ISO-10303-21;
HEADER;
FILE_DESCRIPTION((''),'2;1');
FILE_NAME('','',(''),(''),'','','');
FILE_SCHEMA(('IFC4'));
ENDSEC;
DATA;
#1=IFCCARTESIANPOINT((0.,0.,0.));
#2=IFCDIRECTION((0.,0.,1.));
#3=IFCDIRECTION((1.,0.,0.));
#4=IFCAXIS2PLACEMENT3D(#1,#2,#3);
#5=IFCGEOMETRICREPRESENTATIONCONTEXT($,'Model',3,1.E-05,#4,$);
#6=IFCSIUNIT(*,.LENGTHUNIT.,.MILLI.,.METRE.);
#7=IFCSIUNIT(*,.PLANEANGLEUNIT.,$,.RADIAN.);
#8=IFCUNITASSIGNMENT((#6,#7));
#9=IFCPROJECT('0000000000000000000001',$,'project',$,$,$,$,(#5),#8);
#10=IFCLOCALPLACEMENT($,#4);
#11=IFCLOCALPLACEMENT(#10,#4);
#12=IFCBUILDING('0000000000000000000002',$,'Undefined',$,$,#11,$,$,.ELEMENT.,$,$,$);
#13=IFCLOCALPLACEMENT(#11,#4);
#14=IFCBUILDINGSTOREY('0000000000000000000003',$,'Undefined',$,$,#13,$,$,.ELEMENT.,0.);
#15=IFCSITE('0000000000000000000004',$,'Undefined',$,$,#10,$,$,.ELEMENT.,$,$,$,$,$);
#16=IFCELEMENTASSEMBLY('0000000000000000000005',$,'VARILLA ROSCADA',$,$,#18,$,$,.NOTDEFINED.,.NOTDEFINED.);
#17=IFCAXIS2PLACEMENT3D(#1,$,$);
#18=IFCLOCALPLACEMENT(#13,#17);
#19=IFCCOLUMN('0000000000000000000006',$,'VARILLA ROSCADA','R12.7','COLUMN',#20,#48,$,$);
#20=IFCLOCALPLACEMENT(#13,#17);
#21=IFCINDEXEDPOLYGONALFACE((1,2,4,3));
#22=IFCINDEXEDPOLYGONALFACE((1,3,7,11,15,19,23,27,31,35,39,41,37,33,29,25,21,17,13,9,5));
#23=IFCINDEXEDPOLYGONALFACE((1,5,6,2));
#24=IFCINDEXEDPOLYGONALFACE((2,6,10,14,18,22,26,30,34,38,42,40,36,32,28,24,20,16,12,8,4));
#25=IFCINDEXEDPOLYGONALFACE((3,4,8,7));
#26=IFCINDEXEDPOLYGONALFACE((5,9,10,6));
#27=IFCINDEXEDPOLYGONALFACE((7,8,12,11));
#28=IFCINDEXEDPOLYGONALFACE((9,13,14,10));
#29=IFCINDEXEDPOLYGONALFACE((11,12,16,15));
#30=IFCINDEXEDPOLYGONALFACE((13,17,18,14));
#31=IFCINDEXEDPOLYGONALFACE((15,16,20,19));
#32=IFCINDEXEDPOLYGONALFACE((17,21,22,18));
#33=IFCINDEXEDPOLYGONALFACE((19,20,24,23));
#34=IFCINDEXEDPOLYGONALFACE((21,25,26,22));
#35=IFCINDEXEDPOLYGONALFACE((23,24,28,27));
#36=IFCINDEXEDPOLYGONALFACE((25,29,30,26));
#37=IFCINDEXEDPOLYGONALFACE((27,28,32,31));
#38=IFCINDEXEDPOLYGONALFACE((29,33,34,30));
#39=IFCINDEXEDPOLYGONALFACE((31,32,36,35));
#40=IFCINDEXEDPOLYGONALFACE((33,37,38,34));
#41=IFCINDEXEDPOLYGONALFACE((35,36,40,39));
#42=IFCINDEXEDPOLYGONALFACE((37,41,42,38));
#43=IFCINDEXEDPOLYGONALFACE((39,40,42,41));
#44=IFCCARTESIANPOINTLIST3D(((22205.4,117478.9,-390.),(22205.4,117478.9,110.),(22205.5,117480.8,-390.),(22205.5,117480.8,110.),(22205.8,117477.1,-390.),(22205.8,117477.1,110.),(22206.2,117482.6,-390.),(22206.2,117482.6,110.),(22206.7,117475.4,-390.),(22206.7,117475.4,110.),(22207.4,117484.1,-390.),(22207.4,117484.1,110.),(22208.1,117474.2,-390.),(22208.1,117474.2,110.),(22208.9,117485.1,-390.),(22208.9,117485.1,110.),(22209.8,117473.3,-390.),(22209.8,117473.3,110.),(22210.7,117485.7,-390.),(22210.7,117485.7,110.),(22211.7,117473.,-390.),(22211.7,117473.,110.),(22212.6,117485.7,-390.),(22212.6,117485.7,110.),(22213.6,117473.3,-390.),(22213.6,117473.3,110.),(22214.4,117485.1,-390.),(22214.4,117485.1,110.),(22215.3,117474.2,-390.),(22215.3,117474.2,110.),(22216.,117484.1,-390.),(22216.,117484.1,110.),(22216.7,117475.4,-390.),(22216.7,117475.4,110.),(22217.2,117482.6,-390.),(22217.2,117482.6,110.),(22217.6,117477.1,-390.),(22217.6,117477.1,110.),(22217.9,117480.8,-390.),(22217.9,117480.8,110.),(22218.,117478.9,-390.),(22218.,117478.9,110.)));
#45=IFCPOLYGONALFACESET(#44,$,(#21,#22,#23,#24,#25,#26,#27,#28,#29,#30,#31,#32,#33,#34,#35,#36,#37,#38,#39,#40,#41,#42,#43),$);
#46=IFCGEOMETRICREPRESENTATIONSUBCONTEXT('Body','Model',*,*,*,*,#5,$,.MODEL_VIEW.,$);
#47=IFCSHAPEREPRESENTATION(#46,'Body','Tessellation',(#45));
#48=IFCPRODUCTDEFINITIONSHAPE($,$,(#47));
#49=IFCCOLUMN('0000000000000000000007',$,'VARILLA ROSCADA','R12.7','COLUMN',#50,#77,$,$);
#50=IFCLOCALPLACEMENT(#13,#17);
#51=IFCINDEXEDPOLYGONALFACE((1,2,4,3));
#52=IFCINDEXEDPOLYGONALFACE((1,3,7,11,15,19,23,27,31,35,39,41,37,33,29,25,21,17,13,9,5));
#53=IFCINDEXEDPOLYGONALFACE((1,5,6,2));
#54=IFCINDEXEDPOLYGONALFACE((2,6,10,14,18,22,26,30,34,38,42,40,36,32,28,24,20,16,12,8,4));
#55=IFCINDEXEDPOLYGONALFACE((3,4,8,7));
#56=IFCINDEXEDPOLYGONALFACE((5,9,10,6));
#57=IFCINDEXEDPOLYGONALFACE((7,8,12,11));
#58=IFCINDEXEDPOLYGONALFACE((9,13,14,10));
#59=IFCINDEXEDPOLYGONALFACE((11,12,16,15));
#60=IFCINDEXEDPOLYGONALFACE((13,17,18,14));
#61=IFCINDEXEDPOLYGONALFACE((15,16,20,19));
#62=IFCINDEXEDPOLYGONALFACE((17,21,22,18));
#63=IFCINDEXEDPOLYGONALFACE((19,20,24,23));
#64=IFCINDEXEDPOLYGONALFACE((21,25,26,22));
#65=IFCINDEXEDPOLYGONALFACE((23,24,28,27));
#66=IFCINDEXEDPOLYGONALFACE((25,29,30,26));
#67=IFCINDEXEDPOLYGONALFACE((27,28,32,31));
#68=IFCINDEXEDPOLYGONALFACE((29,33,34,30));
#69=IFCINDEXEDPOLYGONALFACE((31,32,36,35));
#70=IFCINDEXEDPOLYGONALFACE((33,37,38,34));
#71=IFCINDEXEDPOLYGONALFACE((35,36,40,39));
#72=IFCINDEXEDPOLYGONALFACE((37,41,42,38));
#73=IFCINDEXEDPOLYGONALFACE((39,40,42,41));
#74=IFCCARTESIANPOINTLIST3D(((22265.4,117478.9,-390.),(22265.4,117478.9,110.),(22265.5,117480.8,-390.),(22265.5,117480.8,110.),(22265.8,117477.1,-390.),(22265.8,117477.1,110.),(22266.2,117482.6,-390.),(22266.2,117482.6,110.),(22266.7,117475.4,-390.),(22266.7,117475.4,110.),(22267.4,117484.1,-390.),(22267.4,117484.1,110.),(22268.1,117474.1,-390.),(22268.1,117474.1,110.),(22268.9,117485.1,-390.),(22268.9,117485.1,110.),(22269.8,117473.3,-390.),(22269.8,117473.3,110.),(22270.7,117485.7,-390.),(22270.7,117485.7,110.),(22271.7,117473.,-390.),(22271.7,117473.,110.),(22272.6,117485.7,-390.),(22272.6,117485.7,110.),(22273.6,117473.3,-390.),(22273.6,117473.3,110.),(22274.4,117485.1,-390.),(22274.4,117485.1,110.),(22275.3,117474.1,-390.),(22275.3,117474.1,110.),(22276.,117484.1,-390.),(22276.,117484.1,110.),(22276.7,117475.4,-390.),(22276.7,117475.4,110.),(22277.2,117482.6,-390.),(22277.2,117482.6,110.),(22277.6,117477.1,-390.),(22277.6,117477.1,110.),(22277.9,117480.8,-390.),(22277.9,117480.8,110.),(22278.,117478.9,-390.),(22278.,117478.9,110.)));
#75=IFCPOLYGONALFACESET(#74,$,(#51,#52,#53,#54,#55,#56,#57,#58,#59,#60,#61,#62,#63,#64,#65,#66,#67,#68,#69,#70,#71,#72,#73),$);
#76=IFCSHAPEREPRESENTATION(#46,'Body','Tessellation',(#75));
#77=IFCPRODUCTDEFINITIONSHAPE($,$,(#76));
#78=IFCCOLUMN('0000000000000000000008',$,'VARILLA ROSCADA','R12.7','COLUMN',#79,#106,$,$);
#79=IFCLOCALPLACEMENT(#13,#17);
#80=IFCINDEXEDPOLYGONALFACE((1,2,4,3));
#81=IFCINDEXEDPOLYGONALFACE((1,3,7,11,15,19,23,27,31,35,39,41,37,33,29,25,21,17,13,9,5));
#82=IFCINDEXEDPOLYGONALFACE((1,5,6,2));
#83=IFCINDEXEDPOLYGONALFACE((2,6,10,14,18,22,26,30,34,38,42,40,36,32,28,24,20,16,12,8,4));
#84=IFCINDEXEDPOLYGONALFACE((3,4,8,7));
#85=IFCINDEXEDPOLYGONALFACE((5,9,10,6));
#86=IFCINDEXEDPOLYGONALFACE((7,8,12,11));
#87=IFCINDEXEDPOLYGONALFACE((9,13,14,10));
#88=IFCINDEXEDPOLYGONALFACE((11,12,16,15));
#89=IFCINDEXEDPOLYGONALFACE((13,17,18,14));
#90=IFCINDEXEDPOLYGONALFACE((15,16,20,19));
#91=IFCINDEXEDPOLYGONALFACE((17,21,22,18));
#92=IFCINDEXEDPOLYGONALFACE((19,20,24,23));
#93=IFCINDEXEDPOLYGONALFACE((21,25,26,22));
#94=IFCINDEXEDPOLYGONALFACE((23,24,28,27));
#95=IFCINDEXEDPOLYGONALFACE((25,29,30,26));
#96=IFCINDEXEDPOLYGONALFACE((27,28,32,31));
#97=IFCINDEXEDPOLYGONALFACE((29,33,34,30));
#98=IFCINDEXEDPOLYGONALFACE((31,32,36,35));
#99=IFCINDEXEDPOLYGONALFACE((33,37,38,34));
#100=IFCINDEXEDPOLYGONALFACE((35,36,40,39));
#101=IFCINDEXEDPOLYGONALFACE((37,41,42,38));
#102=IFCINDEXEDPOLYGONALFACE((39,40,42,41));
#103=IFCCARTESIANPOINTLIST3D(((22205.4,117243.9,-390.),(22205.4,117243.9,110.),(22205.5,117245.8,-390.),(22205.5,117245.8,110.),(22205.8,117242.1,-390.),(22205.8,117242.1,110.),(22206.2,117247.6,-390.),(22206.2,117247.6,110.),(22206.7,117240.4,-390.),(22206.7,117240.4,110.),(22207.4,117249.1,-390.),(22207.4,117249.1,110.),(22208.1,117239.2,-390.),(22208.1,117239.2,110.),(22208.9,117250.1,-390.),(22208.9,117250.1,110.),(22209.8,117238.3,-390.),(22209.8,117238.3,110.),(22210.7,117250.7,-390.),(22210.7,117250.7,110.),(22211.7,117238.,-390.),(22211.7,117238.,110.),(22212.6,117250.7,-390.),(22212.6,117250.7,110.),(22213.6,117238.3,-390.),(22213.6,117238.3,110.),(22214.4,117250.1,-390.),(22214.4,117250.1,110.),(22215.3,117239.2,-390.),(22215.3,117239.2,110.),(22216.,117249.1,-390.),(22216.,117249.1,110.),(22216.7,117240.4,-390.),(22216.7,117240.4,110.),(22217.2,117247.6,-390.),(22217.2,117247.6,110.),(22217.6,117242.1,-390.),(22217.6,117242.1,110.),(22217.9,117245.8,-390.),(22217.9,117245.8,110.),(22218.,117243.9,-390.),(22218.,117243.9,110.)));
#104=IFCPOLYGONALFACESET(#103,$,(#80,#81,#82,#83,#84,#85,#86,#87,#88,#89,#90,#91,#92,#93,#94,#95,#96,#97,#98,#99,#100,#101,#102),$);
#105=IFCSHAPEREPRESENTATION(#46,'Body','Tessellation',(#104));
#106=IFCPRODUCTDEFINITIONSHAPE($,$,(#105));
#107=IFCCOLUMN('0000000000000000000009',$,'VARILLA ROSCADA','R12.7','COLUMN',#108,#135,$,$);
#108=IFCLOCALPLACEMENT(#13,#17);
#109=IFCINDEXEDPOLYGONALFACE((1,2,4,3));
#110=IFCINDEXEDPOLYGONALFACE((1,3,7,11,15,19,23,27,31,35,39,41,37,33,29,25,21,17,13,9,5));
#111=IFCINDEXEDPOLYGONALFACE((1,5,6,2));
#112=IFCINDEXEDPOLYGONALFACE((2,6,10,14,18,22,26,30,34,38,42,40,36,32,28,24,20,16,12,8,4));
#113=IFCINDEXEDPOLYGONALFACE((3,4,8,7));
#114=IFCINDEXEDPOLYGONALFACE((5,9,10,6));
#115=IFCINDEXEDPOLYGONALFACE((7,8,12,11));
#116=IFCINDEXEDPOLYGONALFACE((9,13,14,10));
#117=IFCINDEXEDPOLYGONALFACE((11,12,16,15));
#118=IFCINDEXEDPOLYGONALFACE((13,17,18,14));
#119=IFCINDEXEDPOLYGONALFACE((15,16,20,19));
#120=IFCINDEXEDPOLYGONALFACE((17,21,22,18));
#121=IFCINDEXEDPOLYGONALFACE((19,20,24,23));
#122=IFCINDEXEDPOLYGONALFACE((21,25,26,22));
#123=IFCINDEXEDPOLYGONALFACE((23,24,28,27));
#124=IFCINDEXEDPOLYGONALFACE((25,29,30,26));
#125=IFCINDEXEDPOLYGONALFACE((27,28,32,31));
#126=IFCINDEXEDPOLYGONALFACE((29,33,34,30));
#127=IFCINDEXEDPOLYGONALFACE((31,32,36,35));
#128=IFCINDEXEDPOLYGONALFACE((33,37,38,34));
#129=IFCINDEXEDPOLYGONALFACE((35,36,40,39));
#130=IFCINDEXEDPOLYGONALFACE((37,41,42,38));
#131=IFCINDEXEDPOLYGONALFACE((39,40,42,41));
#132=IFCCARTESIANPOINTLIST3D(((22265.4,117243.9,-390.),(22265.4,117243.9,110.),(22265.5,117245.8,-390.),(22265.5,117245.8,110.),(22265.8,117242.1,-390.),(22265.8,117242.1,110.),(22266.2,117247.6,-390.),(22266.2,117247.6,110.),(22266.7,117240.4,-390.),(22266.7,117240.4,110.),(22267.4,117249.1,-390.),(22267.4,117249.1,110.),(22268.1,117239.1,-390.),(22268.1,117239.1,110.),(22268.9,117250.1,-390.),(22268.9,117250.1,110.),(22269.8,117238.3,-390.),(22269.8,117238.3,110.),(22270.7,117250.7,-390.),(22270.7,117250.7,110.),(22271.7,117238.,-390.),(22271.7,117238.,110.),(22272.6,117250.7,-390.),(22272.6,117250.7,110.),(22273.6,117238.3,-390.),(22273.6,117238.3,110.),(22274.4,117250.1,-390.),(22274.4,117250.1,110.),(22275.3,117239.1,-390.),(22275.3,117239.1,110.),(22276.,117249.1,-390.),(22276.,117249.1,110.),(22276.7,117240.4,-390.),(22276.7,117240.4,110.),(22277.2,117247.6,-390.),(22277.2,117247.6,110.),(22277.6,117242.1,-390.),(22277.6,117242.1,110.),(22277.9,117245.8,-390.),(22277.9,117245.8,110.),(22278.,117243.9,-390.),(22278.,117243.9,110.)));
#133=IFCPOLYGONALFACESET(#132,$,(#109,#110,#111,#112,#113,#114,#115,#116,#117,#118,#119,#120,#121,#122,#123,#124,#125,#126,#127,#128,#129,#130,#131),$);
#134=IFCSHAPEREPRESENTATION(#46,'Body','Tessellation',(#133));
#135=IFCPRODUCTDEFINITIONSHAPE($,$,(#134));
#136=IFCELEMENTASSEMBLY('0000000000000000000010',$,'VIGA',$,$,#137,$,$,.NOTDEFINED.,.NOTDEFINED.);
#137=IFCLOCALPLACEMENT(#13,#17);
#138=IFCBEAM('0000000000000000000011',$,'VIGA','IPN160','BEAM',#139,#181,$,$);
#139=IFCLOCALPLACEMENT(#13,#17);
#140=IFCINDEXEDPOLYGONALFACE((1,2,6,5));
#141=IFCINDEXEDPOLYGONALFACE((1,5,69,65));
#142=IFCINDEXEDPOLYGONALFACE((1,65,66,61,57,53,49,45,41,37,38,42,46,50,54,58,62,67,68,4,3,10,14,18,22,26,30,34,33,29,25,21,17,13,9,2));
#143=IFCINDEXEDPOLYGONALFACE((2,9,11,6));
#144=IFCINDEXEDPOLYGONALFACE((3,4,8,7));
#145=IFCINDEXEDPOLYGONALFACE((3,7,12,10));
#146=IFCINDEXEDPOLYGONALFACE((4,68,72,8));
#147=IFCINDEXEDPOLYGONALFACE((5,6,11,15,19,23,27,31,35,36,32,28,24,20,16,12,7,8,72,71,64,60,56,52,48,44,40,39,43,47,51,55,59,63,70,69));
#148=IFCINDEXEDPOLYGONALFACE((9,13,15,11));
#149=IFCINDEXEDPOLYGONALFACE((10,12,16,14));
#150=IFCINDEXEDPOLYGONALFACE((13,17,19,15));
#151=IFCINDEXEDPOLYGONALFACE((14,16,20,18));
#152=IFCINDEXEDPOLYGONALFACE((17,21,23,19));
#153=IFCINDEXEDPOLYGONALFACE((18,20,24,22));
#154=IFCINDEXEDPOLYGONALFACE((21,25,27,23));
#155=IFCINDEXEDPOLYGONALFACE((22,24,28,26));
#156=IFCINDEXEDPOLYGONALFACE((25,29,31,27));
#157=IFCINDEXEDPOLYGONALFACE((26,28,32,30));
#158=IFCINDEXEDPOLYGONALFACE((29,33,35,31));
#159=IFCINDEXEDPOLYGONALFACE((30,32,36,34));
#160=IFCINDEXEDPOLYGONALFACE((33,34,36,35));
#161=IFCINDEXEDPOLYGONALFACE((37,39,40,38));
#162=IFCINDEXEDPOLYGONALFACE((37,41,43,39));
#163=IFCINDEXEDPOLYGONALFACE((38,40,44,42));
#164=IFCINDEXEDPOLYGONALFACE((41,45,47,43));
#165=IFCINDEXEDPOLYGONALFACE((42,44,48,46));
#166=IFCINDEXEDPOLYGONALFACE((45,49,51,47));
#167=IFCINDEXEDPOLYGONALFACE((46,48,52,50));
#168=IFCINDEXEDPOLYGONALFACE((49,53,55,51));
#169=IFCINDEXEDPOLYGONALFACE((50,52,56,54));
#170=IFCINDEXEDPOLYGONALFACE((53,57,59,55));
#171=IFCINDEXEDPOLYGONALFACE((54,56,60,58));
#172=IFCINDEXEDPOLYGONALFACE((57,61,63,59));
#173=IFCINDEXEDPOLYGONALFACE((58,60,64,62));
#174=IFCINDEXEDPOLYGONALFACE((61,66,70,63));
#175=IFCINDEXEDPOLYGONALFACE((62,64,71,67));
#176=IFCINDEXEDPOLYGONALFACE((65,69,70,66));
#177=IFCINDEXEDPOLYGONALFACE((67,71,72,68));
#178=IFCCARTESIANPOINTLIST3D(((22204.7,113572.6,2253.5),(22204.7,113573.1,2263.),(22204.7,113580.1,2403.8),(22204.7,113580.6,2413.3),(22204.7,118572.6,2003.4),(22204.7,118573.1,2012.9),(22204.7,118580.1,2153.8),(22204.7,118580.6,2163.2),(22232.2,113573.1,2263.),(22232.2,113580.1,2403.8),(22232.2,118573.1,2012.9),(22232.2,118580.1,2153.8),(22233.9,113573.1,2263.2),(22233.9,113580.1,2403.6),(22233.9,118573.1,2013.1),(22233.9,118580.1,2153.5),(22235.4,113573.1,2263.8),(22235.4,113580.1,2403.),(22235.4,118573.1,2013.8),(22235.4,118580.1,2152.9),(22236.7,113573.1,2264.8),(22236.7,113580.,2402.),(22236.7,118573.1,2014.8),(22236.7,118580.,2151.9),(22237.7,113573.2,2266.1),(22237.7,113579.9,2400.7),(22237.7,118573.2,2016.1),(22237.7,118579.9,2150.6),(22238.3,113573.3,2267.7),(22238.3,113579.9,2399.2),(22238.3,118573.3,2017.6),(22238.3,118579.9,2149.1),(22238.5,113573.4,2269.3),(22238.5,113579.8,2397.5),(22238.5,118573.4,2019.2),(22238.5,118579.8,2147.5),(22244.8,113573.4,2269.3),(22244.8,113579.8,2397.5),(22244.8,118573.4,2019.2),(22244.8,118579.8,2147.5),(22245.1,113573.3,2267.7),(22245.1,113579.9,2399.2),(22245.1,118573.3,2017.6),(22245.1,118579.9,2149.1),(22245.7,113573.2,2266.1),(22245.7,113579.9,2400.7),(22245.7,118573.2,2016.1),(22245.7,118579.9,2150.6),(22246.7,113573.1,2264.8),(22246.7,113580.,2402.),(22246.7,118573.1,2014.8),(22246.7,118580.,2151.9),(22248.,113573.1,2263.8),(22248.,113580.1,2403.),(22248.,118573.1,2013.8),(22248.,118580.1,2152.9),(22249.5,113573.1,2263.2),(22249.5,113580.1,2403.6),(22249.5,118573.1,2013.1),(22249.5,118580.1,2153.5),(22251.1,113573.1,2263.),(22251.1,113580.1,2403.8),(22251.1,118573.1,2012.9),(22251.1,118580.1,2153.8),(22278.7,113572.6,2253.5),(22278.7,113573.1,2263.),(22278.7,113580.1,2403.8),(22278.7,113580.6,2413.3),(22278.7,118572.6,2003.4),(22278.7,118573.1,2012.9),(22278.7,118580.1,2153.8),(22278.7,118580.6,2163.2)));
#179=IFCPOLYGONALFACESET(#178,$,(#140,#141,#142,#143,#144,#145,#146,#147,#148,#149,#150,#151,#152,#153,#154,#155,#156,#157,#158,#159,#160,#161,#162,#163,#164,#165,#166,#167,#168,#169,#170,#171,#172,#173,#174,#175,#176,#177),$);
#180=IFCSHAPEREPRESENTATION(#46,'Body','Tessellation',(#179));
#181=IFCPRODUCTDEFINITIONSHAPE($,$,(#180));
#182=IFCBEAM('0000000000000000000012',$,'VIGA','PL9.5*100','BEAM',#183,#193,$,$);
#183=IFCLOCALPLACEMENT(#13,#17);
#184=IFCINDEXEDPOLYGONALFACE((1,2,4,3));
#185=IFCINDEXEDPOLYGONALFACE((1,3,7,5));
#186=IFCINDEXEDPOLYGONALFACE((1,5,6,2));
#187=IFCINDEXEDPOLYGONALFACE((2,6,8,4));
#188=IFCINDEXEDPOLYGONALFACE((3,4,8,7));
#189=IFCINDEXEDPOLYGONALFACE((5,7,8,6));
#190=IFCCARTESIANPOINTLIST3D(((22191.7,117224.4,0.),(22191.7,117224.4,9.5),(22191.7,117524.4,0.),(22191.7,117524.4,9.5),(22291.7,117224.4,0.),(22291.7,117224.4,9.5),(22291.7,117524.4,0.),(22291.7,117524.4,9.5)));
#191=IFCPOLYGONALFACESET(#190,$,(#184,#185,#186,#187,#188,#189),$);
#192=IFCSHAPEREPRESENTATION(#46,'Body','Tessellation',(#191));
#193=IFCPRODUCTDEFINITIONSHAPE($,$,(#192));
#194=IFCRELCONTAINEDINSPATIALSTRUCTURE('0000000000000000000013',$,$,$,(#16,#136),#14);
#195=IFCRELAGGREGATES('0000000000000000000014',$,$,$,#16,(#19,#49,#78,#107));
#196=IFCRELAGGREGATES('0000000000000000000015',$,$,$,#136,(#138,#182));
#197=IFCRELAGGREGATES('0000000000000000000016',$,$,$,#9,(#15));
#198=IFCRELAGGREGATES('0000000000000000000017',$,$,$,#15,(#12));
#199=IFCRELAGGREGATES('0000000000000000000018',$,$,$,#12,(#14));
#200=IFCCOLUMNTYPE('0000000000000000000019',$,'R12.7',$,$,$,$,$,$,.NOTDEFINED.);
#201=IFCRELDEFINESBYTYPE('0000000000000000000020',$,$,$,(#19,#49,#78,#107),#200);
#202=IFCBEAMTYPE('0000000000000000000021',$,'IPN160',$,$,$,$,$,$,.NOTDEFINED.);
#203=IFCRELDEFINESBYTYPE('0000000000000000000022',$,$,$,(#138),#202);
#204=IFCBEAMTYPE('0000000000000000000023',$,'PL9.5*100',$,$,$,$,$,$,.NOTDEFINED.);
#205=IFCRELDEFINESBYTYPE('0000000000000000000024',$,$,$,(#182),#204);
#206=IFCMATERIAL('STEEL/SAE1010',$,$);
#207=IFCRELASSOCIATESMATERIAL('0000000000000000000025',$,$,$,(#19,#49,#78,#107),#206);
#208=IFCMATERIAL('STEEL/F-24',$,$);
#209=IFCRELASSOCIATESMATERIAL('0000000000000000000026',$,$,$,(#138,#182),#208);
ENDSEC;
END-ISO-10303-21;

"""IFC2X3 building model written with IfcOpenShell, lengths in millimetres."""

from ifc_helpers import new_model, si_unit, frame, origin_with_axes, origin_2d_with_axis, place, context, subcontext, project, spatial, rectangle, circle, i_section, extrude, material, type_object, element, aggregate, save


model = new_model("IFC2X3")

# Units and contexts
model_context = context("Model", 3, precision=1e-05, world=origin_with_axes())
body_context = subcontext(model_context, "Body", "Model", "MODEL_VIEW")
ifc_project = project(units=[si_unit("LENGTHUNIT", "METRE", prefix="MILLI"), si_unit("PLANEANGLEUNIT", "RADIAN")], contexts=[model_context])

# Site, building, storey
site_placement = place(None, origin_with_axes())
site = spatial("IfcSite", under=ifc_project, at=site_placement, Name="Undefined", CompositionType="ELEMENT")
building_placement = place(site_placement, origin_with_axes())
building = spatial("IfcBuilding", under=site, at=building_placement, Name="Undefined", CompositionType="ELEMENT")
storey_placement = place(building_placement, origin_with_axes())
storey = spatial("IfcBuildingStorey", under=building, at=storey_placement, Name="Undefined", CompositionType="ELEMENT", Elevation=0.0)

# Element assembly, columns
assembly_1_placement = place(storey_placement, origin_with_axes())
assembly_1 = element("IfcElementAssembly", 1, at=assembly_1_placement, inside=storey, Name="VARILLA ROSCADA", AssemblyPlace="NOTDEFINED", PredefinedType="NOTDEFINED")
ifc_material_1 = material(Name="STEEL/SAE1010")
column_type = type_object("IfcColumnType", Name="R12.7", PredefinedType="NOTDEFINED")
column_1_placement = place(assembly_1_placement, frame((22211.7, 117479.4, -390.0), z_axis=(0.0, 0.0, 1.0), x_axis=(-1.0, 0.0, 0.0)))
column_1 = element("IfcColumn", 2, at=column_1_placement, type_object=column_type, material=ifc_material_1, Name="VARILLA ROSCADA", Description="R12.7", ObjectType="COLUMN", context=body_context, shape_type="SweptSolid", body=[
    extrude(circle(Radius=6.3, at=origin_2d_with_axis()), frame((0.0, 0.0, 500.0), z_axis=(0.0, 0.0, -1.0), x_axis=(0.0, 1.0, 0.0)), (0.0, 0.0, 1.0), 500.0),
])
column_2_placement = place(assembly_1_placement, frame((22271.7, 117479.4, -390.0), z_axis=(0.0, 0.0, 1.0), x_axis=(-1.0, 0.0, 0.0)))
column_2 = element("IfcColumn", 3, at=column_2_placement, type_object=column_type, material=ifc_material_1, Name="VARILLA ROSCADA", Description="R12.7", ObjectType="COLUMN", context=body_context, shape_type="SweptSolid", body=[
    extrude(circle(Radius=6.3, at=origin_2d_with_axis()), frame((0.0, 0.0, 500.0), z_axis=(0.0, 0.0, -1.0), x_axis=(0.0, 1.0, 0.0)), (0.0, 0.0, 1.0), 500.0),
])
column_3_placement = place(assembly_1_placement, frame((22211.7, 117244.4, -390.0), z_axis=(0.0, 0.0, 1.0), x_axis=(-1.0, 0.0, 0.0)))
column_3 = element("IfcColumn", 4, at=column_3_placement, type_object=column_type, material=ifc_material_1, Name="VARILLA ROSCADA", Description="R12.7", ObjectType="COLUMN", context=body_context, shape_type="SweptSolid", body=[
    extrude(circle(Radius=6.3, at=origin_2d_with_axis()), frame((0.0, 0.0, 500.0), z_axis=(0.0, 0.0, -1.0), x_axis=(0.0, 1.0, 0.0)), (0.0, 0.0, 1.0), 500.0),
])
column_4_placement = place(assembly_1_placement, frame((22271.7, 117244.4, -390.0), z_axis=(0.0, 0.0, 1.0), x_axis=(-1.0, 0.0, 0.0)))
column_4 = element("IfcColumn", 5, at=column_4_placement, type_object=column_type, material=ifc_material_1, Name="VARILLA ROSCADA", Description="R12.7", ObjectType="COLUMN", context=body_context, shape_type="SweptSolid", body=[
    extrude(circle(Radius=6.3, at=origin_2d_with_axis()), frame((0.0, 0.0, 500.0), z_axis=(0.0, 0.0, -1.0), x_axis=(0.0, 1.0, 0.0)), (0.0, 0.0, 1.0), 500.0),
])

# Element assembly, beams
assembly_2_placement = place(storey_placement, origin_with_axes())
assembly_2 = element("IfcElementAssembly", 6, at=assembly_2_placement, inside=storey, Name="VIGA", AssemblyPlace="NOTDEFINED", PredefinedType="NOTDEFINED")
ifc_material_2 = material(Name="STEEL/F-24")
beam_type_1 = type_object("IfcBeamType", Name="IPN160", PredefinedType="NOTDEFINED")
beam_1_placement = place(assembly_2_placement, frame((22241.7, 118576.6, 2083.3), z_axis=(0.0, 0.04995, 0.998752), x_axis=(0.0, -0.998752, 0.04995)))
beam_1 = element("IfcBeam", 7, at=beam_1_placement, type_object=beam_type_1, material=ifc_material_2, Name="VIGA", Description="IPN160", ObjectType="BEAM", context=body_context, shape_type="SweptSolid", body=[
    extrude(i_section(OverallWidth=74.0, OverallDepth=160.0, WebThickness=6.3, FlangeThickness=9.5, FilletRadius=6.3, at=origin_2d_with_axis()), frame((5006.2, 0.0, 0.0), z_axis=(-1.0, 0.0, 0.0), x_axis=(0.0, -1.0, 0.0)), (0.0, 0.0, 1.0), 5006.2),
])
beam_type_2 = type_object("IfcBeamType", Name="PL9.5*100", PredefinedType="NOTDEFINED")
beam_2_placement = place(assembly_2_placement, frame((22241.7, 117524.4, 4.7), z_axis=(1.0, 0.0, 0.0), x_axis=(0.0, -1.0, 0.0)))
beam_2 = element("IfcBeam", 8, at=beam_2_placement, type_object=beam_type_2, material=ifc_material_2, Name="VIGA", Description="PL9.5*100", ObjectType="BEAM", context=body_context, shape_type="SweptSolid", body=[
    extrude(rectangle(XDim=9.5, YDim=100.0, at=origin_2d_with_axis()), frame((300.0, 0.0, 0.0), z_axis=(-1.0, 0.0, 0.0), x_axis=(0.0, -1.0, 0.0)), (0.0, 0.0, 1.0), 300.0),
])

aggregate(assembly_1, [column_1, column_2, column_3, column_4])

aggregate(assembly_2, [beam_1, beam_2])

save(model, "model.ifc")
